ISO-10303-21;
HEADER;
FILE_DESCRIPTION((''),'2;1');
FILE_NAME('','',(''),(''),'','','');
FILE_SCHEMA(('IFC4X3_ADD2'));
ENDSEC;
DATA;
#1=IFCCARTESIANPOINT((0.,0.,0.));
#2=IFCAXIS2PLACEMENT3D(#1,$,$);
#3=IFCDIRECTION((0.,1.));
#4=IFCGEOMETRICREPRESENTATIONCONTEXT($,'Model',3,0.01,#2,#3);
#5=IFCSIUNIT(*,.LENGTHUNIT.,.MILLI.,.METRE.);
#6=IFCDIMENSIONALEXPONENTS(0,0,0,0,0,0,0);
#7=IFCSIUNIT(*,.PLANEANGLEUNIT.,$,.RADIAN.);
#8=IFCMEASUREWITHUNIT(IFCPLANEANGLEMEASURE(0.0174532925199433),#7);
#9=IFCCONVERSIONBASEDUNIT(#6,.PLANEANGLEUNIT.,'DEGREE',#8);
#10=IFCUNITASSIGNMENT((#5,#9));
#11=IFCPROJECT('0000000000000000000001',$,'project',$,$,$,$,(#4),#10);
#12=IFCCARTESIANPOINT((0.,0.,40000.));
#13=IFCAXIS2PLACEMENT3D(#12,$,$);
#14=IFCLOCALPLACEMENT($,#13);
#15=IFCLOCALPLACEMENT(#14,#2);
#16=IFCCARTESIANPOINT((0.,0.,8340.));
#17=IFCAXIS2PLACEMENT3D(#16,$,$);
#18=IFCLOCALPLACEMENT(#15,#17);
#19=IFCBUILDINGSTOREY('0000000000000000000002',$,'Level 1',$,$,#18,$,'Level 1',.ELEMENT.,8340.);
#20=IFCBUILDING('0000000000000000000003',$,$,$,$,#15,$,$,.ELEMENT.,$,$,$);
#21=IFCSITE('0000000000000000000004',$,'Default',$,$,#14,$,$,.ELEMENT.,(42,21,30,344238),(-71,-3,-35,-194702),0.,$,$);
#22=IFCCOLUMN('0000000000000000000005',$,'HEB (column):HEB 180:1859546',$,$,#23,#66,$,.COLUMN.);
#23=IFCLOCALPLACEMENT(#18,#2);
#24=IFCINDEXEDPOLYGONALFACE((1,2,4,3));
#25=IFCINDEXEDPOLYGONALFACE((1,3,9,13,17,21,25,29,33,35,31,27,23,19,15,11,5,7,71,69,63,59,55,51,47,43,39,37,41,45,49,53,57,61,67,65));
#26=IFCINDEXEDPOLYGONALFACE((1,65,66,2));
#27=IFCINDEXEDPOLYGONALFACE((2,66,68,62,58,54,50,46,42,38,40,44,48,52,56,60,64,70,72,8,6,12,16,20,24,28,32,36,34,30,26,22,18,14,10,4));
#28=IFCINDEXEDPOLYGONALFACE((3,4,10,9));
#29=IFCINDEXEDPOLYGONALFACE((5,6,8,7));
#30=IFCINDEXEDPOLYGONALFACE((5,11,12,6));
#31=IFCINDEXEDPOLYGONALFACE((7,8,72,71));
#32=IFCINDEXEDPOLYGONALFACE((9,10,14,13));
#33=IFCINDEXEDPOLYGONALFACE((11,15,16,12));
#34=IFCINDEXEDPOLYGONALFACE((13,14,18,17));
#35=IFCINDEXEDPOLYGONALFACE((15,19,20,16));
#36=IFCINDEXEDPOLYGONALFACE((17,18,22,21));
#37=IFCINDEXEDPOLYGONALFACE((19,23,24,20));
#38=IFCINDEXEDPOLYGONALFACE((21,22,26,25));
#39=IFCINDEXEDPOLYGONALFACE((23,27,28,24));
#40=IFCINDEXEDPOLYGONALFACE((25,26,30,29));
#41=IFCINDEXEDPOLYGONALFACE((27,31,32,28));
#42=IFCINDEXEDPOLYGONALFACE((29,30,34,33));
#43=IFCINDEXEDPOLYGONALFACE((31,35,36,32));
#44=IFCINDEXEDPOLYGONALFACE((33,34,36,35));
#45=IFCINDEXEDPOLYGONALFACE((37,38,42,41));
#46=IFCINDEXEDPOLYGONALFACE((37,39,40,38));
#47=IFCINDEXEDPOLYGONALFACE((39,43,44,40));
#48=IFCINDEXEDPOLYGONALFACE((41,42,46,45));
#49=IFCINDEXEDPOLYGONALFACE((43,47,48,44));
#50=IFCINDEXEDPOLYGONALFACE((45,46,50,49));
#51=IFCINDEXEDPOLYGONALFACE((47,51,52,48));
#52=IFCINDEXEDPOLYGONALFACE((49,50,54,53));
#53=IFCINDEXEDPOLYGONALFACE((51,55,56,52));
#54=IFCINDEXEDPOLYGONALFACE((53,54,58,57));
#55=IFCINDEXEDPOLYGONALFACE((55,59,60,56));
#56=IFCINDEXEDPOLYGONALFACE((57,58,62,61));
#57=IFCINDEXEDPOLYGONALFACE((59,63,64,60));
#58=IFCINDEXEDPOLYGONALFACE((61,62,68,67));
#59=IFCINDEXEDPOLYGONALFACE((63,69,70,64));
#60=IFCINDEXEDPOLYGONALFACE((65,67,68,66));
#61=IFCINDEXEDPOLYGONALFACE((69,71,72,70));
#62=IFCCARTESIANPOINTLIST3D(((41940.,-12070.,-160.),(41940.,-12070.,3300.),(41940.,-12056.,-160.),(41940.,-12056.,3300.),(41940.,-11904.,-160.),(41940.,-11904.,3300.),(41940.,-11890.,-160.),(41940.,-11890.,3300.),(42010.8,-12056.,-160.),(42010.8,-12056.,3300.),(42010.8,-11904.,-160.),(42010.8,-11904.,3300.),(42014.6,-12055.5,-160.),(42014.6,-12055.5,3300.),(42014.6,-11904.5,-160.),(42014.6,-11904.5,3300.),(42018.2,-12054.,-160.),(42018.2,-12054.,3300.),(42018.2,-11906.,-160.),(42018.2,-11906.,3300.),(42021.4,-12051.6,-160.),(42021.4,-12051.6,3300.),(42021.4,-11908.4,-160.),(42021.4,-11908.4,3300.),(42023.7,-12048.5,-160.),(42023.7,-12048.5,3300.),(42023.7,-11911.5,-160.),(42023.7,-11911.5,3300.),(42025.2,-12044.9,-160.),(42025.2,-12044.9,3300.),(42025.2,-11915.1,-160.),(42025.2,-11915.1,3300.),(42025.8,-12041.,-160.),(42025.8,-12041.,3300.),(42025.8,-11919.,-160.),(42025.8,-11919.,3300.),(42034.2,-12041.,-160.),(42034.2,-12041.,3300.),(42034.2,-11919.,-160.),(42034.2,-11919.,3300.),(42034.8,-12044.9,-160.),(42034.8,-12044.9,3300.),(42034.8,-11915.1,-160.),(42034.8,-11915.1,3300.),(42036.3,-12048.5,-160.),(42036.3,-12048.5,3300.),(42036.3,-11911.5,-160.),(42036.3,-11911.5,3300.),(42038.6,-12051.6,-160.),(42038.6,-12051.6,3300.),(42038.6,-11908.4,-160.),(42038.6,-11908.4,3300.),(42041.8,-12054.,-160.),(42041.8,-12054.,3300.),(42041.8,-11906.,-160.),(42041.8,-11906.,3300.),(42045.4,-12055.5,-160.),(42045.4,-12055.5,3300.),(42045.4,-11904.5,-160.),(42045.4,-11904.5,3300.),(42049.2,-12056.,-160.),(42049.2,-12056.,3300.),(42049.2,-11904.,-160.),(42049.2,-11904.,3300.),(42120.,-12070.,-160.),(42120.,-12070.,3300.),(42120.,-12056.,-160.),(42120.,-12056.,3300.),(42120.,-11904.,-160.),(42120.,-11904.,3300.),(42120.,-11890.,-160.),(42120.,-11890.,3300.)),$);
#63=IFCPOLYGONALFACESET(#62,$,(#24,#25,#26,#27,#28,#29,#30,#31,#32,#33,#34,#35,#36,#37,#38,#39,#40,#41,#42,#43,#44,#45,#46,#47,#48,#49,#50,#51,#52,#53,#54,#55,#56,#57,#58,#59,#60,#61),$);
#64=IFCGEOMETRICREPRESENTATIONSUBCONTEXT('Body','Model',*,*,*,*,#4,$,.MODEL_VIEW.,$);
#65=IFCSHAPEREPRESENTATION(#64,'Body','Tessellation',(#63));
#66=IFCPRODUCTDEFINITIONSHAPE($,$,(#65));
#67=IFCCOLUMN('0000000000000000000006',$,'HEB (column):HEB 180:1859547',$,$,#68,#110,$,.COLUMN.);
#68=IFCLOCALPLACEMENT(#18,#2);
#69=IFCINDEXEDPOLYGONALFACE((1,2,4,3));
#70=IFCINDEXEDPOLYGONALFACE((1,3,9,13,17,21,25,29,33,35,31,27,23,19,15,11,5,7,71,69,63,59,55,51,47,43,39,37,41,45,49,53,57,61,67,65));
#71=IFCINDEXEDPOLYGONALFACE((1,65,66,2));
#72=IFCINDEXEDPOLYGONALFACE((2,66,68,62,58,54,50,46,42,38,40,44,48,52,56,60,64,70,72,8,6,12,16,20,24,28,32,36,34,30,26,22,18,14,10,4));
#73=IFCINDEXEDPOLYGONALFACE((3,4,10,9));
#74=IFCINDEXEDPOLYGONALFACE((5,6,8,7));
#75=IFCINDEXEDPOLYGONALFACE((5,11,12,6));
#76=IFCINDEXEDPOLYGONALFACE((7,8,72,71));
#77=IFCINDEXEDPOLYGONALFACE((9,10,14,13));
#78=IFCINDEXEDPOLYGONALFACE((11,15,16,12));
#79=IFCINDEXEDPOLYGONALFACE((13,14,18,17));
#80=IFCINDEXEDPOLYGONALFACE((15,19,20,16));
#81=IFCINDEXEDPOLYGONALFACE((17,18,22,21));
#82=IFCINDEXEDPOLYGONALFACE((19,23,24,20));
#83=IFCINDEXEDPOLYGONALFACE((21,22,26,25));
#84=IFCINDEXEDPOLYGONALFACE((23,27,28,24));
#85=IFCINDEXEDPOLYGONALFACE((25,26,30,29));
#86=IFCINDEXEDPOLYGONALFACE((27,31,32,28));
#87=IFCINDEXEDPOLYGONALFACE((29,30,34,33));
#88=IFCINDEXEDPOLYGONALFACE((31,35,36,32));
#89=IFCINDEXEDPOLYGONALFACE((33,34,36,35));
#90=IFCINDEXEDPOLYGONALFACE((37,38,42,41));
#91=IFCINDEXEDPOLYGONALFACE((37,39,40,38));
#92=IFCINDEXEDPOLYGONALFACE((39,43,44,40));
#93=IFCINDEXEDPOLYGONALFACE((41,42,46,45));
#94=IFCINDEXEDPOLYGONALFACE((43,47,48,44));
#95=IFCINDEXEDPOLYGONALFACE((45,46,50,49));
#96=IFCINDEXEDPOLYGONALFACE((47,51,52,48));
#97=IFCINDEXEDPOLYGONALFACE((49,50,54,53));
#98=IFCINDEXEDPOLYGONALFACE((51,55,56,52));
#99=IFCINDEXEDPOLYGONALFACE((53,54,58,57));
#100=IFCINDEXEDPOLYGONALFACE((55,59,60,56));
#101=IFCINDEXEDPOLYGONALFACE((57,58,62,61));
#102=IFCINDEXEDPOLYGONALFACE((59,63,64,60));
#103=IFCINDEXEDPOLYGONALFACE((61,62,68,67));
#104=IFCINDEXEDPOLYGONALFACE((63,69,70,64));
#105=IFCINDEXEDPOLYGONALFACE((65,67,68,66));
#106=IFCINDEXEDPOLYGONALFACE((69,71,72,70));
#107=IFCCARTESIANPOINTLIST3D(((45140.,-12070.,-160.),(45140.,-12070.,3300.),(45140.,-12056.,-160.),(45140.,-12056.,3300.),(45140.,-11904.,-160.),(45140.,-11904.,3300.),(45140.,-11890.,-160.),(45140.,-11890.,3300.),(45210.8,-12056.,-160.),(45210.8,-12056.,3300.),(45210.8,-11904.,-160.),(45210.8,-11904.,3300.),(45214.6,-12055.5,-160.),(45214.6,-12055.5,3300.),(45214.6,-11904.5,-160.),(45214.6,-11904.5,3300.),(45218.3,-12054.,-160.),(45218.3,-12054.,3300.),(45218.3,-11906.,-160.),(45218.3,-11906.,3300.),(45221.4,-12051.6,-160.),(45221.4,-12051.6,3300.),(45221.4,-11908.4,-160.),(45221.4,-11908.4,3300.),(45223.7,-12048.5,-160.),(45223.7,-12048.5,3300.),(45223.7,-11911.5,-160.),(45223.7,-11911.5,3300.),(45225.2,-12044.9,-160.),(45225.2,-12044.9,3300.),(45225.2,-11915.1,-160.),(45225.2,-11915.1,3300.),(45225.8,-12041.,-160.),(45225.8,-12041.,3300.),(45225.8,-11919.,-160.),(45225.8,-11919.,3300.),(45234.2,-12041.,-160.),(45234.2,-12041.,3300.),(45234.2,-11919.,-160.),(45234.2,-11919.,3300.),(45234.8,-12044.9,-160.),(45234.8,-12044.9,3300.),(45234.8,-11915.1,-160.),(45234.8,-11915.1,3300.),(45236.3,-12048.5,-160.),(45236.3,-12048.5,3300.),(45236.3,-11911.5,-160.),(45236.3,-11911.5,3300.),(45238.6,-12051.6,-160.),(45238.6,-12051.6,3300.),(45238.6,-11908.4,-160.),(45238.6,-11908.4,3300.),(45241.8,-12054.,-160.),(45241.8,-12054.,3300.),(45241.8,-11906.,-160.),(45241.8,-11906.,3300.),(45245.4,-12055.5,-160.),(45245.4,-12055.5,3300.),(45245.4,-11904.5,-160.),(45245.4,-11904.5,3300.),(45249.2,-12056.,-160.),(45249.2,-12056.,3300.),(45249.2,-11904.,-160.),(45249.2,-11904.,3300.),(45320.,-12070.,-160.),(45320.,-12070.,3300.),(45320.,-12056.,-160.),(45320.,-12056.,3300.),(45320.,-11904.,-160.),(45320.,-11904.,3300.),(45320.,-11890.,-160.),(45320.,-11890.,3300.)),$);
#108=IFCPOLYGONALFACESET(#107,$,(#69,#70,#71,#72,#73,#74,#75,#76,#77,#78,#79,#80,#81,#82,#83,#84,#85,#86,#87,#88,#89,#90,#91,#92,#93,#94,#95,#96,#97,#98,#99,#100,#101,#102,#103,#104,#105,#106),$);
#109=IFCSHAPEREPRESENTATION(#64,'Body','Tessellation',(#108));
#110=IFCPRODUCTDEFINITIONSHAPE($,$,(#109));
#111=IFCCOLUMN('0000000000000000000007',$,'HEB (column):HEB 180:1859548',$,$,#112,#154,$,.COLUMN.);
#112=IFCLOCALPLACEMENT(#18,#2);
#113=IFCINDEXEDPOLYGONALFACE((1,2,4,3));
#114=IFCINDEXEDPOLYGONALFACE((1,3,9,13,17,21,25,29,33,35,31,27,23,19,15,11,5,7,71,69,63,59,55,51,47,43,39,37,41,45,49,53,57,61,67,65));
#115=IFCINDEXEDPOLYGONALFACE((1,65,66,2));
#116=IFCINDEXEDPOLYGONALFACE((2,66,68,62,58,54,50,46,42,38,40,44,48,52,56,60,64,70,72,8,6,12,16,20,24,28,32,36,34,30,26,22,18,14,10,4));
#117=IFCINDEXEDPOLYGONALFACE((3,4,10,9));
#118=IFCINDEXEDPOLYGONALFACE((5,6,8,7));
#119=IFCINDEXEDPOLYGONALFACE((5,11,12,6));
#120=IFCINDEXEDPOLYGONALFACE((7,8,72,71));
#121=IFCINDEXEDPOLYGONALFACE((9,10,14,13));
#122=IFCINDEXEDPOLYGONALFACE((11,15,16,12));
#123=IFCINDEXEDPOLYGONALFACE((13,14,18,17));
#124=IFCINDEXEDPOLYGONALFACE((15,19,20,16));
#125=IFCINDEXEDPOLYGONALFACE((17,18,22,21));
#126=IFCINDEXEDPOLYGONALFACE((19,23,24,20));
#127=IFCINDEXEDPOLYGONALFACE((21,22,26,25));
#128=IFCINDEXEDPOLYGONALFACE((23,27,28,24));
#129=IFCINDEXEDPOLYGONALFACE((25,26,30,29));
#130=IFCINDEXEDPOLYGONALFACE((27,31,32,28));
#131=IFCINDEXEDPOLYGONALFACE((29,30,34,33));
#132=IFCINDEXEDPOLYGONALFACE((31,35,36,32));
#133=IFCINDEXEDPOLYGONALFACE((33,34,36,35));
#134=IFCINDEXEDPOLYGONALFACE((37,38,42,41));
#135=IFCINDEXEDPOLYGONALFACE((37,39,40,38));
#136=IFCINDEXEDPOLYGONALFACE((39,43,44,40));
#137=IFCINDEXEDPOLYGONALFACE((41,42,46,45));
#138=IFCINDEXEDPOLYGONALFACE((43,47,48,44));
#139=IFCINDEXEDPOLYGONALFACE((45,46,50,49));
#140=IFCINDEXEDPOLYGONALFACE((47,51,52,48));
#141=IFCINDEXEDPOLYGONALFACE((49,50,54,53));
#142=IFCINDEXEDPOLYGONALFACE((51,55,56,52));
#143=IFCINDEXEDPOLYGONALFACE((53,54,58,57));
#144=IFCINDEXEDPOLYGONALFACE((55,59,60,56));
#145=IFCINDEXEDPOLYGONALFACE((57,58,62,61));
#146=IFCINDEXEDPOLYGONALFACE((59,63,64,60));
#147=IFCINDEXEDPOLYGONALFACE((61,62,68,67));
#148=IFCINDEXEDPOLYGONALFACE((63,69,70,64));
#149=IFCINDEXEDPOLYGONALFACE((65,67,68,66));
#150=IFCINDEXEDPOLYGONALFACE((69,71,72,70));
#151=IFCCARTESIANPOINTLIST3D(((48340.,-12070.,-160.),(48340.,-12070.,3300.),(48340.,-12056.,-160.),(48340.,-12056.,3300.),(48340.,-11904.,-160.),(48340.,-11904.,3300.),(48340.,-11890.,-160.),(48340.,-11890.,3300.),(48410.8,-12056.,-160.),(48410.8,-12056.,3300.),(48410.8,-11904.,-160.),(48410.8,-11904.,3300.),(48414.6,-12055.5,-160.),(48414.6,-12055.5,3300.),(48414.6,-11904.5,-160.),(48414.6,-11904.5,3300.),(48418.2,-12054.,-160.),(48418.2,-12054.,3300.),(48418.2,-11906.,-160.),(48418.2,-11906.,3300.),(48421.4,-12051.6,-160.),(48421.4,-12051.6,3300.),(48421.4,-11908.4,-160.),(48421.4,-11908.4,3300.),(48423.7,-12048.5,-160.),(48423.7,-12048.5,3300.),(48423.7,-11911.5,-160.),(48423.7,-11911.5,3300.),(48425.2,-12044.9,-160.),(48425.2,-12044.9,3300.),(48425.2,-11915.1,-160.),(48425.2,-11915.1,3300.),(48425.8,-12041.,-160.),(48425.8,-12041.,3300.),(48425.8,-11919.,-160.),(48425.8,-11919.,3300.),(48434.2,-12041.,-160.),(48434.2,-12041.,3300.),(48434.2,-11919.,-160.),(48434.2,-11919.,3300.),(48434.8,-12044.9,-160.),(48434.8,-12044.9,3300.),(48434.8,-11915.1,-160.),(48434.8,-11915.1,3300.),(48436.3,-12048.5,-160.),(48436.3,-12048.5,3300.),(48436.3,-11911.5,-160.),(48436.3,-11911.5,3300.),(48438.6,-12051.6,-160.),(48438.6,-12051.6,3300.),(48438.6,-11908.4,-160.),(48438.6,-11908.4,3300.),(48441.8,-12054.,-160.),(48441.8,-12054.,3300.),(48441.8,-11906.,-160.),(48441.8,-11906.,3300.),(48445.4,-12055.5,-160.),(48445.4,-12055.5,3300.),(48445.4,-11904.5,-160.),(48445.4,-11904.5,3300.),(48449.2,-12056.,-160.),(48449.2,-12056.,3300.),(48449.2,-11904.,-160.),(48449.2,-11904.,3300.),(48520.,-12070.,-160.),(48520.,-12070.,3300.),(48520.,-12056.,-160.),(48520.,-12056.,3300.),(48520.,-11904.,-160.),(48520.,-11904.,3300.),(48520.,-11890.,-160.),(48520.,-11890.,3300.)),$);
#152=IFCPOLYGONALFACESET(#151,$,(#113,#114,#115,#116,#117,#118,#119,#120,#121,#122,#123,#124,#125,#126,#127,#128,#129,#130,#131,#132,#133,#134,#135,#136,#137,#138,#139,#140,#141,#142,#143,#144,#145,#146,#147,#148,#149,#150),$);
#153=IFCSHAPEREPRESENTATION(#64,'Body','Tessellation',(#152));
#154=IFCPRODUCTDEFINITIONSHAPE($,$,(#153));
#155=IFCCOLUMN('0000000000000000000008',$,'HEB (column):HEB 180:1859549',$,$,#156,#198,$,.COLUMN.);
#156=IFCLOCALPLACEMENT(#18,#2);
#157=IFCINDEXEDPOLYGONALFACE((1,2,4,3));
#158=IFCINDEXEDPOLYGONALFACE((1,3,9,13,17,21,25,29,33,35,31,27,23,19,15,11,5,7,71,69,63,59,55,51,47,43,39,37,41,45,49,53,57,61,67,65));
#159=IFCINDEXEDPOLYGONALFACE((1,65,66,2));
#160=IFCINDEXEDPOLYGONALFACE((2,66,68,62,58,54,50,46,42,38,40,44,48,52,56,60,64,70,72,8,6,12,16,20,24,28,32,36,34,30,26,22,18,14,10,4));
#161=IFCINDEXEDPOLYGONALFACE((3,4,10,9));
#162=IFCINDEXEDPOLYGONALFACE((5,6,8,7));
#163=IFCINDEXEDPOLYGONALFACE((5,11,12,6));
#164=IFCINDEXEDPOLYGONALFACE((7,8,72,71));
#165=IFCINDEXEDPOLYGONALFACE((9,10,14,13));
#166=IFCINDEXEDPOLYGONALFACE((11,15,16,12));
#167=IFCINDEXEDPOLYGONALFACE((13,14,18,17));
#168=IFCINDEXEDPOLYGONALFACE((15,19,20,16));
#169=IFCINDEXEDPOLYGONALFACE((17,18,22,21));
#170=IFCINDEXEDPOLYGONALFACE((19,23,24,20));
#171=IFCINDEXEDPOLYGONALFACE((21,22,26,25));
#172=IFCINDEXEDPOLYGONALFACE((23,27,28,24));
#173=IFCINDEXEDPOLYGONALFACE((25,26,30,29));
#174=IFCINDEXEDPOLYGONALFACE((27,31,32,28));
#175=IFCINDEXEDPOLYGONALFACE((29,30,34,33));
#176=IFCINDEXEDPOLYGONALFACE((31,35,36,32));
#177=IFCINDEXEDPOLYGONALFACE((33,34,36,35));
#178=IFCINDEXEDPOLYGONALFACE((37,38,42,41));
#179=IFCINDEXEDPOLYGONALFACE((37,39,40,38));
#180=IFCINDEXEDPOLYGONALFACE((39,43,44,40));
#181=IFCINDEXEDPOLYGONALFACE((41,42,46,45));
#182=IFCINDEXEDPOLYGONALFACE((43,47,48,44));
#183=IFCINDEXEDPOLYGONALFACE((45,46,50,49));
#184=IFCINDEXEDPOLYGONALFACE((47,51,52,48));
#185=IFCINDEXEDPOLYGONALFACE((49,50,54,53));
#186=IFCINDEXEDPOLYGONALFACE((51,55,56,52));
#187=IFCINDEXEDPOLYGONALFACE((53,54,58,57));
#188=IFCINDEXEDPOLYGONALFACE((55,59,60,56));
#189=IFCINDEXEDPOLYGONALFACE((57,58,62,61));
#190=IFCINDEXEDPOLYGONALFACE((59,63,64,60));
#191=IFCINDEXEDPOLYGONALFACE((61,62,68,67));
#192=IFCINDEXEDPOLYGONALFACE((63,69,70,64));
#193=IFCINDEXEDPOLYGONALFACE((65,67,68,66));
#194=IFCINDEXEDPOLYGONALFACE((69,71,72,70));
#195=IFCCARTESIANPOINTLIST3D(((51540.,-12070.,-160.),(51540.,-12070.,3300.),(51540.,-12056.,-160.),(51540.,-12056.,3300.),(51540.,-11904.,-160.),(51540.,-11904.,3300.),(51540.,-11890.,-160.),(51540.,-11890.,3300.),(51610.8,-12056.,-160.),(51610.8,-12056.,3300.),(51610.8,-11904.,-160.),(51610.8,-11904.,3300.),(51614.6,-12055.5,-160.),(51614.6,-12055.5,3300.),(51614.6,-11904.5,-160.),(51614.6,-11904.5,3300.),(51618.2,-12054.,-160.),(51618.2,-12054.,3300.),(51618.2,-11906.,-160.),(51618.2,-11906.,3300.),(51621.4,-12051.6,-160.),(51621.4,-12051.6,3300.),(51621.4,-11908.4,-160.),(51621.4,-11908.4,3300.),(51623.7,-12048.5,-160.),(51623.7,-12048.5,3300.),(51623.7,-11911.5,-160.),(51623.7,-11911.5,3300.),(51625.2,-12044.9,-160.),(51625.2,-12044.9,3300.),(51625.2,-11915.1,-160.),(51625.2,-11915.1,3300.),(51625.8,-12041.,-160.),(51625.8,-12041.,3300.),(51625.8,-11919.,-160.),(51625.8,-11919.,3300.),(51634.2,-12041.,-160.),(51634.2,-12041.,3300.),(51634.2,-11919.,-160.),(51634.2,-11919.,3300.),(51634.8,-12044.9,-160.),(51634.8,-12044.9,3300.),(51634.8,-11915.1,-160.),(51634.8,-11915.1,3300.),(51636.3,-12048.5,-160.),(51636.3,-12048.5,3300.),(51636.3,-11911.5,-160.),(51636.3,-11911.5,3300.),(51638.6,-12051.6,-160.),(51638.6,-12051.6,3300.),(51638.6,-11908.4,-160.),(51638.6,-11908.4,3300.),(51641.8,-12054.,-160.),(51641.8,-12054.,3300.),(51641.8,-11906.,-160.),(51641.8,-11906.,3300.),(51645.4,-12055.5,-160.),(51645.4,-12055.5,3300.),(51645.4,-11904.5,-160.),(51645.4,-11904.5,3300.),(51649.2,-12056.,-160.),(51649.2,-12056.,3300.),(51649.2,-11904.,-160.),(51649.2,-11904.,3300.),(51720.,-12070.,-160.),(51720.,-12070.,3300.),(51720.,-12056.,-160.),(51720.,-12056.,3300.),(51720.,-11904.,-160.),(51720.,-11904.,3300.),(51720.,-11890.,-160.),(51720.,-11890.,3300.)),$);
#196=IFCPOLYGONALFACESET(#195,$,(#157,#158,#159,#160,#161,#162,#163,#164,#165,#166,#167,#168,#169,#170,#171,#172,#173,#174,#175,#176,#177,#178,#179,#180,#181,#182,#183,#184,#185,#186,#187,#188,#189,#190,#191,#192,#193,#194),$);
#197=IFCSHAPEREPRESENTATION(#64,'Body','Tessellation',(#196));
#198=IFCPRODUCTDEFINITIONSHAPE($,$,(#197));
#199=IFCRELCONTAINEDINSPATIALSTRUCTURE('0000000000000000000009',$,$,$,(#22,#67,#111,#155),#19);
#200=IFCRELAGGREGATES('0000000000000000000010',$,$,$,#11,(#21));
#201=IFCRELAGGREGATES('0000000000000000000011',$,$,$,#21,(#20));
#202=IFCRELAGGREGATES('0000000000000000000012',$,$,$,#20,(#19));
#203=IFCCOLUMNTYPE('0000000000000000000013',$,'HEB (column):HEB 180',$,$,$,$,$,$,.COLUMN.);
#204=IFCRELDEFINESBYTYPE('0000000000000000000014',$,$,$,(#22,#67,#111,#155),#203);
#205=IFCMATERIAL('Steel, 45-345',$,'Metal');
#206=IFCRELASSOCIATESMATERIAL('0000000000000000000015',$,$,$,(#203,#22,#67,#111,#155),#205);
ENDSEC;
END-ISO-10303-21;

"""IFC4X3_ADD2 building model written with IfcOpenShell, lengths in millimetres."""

from ifc_helpers import new_model, entity, si_unit, converted_unit, direction, frame, origin, origin_2d_with_axis, place, context, subcontext, project, spatial, i_section, extrude, source, transform, mapped, material, material_profile, profile_set, profile_usage, type_object, type_shapes, element, save


model = new_model("IFC4X3_ADD2")

# Units and contexts
model_context = context("Model", 3, precision=0.01, world=origin(), true_north=direction((0.0, 1.0)))
body_context = subcontext(model_context, "Body", "Model", "MODEL_VIEW")
ifc_project = project(units=[si_unit("LENGTHUNIT", "METRE", prefix="MILLI"), converted_unit("PLANEANGLEUNIT", "DEGREE", entity("IfcPlaneAngleMeasure", 0.0174532925199433), si_unit("PLANEANGLEUNIT", "RADIAN"), dimensions=[0, 0, 0, 0, 0, 0, 0])], contexts=[model_context])

# Site, building, storey
site_placement = place(None, frame((0.0, 0.0, 40000.0)))
site = spatial("IfcSite", under=ifc_project, at=site_placement, Name="Default", CompositionType="ELEMENT", RefLatitude=(42, 21, 30, 344238), RefLongitude=(-71, -3, -35, -194702), RefElevation=0.0)
building_placement = place(site_placement, origin())
building = spatial("IfcBuilding", under=site, at=building_placement, CompositionType="ELEMENT")
storey_placement = place(building_placement, frame((0.0, 0.0, 8340.0)))
storey = spatial("IfcBuildingStorey", under=building, at=storey_placement, Name="Level 1", LongName="Level 1", CompositionType="ELEMENT", Elevation=8340.0)

# Columns
ifc_material = material(Name="Steel, 45-345", Category="Metal")
ifc_material_profile_1 = material_profile(ifc_material, i_section(OverallWidth=180.0, OverallDepth=180.0, WebThickness=8.5, FlangeThickness=14.0, FilletRadius=15.0, at=origin_2d_with_axis()), Name="HEB 180")
ifc_profile_set_1 = profile_set([ifc_material_profile_1], Name="HEB 180")
ifc_profile_usage_1 = profile_usage(ifc_profile_set_1)
column_type_1 = type_object("IfcColumnType", Name="HEB (column):HEB 180", PredefinedType="COLUMN", material=ifc_profile_set_1)
shared_shape_1 = source(origin(), body_context, "Body", "SweptSolid", [
    extrude(i_section(OverallWidth=180.0, OverallDepth=180.0, WebThickness=8.5, FlangeThickness=14.0, FilletRadius=15.0, at=origin_2d_with_axis()), frame((0.0, 0.0, 8180.0), z_axis=(0.0, 0.0, 1.0), x_axis=(-1.0, 0.0, 0.0)), (0.0, 0.0, 1.0), 3460.0),
])
type_shapes(column_type_1, [shared_shape_1])
for number, where, name in (
    (1, (42030.0, -11980.0, -8340.0), "HEB (column):HEB 180:1859546"),
    (2, (45230.0, -11980.0, -8340.0), "HEB (column):HEB 180:1859547"),
    (3, (48430.0, -11980.0, -8340.0), "HEB (column):HEB 180:1859548"),
    (4, (51630.0, -11980.0, -8340.0), "HEB (column):HEB 180:1859549"),
):
    element("IfcColumn", number, at=place(storey_placement, frame(where)), inside=storey, type_object=column_type_1, material=ifc_profile_usage_1, Name=name, PredefinedType="COLUMN", context=body_context, shape_type="MappedRepresentation", body=[
        mapped(shared_shape_1, transform((0.0, 0.0, 0.0), scale=1.0)),
    ])

save(model, "model.ifc")
